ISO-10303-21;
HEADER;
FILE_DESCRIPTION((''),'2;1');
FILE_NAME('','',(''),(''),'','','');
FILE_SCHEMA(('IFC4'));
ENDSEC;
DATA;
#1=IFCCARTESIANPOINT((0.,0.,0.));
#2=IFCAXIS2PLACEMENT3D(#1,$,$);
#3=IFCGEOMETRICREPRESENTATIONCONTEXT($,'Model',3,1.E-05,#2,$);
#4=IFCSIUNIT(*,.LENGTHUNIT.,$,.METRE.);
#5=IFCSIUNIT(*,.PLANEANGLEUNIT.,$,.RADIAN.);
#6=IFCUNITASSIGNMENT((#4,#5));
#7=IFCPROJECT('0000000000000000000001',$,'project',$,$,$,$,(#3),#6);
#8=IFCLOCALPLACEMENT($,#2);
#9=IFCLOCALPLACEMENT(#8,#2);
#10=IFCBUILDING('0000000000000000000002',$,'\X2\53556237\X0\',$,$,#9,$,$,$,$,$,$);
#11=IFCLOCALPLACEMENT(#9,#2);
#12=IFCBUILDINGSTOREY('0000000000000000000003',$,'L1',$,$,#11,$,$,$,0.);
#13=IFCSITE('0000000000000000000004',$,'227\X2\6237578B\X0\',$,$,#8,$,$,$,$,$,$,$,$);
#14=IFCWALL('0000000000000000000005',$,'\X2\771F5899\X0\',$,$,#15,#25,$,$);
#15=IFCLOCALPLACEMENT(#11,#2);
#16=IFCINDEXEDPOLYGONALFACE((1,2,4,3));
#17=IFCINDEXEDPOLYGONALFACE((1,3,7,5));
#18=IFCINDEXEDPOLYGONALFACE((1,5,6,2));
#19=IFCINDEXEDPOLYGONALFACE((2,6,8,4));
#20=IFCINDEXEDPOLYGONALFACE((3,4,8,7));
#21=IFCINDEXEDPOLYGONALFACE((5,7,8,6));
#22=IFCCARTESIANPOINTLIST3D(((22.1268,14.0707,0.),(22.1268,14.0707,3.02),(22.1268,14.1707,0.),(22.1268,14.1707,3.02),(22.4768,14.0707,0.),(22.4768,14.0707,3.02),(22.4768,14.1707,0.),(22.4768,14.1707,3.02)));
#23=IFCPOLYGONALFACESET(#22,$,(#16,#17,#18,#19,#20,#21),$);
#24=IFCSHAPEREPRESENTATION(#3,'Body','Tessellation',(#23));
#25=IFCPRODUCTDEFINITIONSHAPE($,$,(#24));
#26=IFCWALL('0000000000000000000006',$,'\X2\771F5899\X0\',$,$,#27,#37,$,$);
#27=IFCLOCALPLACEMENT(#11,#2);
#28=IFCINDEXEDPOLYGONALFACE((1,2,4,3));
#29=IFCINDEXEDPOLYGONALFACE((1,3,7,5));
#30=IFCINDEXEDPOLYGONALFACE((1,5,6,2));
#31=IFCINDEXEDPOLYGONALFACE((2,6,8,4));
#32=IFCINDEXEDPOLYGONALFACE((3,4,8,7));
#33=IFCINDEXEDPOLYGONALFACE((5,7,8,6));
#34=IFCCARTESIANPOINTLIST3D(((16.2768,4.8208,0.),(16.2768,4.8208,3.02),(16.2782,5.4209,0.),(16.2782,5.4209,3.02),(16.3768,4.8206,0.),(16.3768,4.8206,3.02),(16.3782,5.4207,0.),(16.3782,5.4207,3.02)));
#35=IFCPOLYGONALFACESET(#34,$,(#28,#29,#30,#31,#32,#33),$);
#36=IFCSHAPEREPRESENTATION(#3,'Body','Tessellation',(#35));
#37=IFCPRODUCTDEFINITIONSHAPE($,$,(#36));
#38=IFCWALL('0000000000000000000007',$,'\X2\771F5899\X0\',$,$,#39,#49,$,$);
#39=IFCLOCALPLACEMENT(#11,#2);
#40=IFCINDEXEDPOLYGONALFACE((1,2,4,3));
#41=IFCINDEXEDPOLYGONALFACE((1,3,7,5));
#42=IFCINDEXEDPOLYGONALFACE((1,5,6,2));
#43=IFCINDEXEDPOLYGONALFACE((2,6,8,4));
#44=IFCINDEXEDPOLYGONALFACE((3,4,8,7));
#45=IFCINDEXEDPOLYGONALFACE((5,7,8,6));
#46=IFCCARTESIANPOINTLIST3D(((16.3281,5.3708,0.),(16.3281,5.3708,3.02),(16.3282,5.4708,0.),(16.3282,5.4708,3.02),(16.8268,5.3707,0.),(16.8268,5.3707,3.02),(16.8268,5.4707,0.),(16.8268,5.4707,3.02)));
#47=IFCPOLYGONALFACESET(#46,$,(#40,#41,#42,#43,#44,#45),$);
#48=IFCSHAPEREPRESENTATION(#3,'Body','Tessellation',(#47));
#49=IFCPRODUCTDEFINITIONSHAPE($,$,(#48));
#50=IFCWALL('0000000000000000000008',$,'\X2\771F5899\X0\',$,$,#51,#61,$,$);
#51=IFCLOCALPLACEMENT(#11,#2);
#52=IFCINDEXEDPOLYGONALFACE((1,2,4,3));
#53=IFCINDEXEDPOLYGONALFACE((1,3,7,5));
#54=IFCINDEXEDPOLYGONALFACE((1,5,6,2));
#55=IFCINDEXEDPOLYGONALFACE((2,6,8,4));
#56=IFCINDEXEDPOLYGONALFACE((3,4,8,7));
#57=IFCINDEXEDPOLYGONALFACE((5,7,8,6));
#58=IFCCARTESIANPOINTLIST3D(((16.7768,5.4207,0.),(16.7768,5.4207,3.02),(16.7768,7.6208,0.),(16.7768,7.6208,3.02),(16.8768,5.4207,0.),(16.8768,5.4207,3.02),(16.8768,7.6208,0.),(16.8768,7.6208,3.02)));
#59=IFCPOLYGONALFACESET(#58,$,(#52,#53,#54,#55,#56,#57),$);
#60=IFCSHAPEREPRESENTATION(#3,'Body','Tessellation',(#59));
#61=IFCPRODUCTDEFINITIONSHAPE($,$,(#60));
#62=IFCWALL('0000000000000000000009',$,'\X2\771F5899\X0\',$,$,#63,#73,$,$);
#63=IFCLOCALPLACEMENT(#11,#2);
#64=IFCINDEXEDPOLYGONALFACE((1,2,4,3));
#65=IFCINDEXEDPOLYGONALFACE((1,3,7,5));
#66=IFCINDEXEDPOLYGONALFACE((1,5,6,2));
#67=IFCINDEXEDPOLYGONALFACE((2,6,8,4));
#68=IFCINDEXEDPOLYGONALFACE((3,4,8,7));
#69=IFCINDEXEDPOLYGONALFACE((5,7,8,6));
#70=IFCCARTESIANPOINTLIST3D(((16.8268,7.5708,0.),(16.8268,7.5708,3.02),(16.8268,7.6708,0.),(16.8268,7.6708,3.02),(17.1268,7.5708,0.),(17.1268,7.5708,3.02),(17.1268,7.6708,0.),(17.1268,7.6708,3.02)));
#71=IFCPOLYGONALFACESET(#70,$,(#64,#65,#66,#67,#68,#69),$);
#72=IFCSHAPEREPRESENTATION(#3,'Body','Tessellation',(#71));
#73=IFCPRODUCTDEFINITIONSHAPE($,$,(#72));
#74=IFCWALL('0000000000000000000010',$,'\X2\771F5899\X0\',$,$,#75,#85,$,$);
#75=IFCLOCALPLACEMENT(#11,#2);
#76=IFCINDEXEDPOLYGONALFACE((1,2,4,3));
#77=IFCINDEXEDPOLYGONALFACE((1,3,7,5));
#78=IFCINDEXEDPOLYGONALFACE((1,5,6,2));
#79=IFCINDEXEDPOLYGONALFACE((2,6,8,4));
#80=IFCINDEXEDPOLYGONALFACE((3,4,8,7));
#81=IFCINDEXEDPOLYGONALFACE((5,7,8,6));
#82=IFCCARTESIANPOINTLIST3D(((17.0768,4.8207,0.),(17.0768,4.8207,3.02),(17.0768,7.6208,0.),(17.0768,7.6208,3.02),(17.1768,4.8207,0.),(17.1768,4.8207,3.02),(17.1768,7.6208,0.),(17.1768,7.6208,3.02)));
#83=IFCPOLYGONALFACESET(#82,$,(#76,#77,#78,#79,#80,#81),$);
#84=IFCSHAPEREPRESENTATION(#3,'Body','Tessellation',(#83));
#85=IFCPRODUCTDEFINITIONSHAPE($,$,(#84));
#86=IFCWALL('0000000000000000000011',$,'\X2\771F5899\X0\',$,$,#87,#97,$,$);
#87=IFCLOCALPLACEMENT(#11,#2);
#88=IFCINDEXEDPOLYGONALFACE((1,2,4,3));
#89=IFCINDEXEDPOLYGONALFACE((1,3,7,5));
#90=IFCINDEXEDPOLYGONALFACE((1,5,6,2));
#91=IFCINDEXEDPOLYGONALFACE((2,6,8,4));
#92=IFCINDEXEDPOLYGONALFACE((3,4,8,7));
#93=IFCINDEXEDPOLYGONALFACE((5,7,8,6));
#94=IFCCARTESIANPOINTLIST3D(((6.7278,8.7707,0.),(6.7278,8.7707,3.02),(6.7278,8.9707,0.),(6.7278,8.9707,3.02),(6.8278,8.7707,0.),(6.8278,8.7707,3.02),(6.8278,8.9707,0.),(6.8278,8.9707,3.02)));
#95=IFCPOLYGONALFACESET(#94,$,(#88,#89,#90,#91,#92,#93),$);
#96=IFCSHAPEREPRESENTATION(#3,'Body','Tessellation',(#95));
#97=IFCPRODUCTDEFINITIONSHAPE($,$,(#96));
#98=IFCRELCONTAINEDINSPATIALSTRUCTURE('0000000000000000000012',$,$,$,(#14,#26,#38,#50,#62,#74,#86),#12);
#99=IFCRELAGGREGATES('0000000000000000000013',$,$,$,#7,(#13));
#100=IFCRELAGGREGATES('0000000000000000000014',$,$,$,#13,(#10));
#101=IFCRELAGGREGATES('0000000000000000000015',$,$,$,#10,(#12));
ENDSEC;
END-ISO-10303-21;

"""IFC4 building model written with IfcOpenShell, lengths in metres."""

from ifc_helpers import new_model, si_unit, origin, place, context, project, spatial, polyline, outline, extrude, element, save


model = new_model("IFC4")

# Units and contexts
model_context = context("Model", 3, precision=1e-05, world=origin())
ifc_project = project(units=[si_unit("LENGTHUNIT", "METRE"), si_unit("PLANEANGLEUNIT", "RADIAN")], contexts=[model_context])

# Site, building, storey
site_placement = place(None, origin())
site = spatial("IfcSite", under=ifc_project, at=site_placement, Name="227户型")
building_placement = place(site_placement, origin())
building = spatial("IfcBuilding", under=site, at=building_placement, Name="单户")
storey_placement = place(building_placement, origin())
storey = spatial("IfcBuildingStorey", under=building, at=storey_placement, Name="L1", Elevation=0.0)

# Walls
wall_1_placement = place(storey_placement, origin())
element("IfcWall", 1, at=wall_1_placement, inside=storey, Name="真墙", context=model_context, shape_type="SweptSolid", body=[
    extrude(outline(polyline([(22.4768, 14.0707), (22.1268, 14.0707), (22.1268, 14.1707), (22.4768, 14.1707), (22.4768, 14.0707)])), origin(), (0.0, 0.0, 1.0), 3.02),
])
wall_2_placement = place(storey_placement, origin())
element("IfcWall", 2, at=wall_2_placement, inside=storey, Name="真墙", context=model_context, shape_type="SweptSolid", body=[
    extrude(outline(polyline([(16.2768, 4.8208), (16.2782, 5.4209), (16.3782, 5.4207), (16.3768, 4.8206), (16.2768, 4.8208)])), origin(), (0.0, 0.0, 1.0), 3.02),
])
wall_3_placement = place(storey_placement, origin())
element("IfcWall", 3, at=wall_3_placement, inside=storey, Name="真墙", context=model_context, shape_type="SweptSolid", body=[
    extrude(outline(polyline([(16.3282, 5.4708), (16.8268, 5.4707), (16.8268, 5.3707), (16.3281, 5.3708), (16.3282, 5.4708)])), origin(), (0.0, 0.0, 1.0), 3.02),
])
wall_4_placement = place(storey_placement, origin())
element("IfcWall", 4, at=wall_4_placement, inside=storey, Name="真墙", context=model_context, shape_type="SweptSolid", body=[
    extrude(outline(polyline([(16.7768, 5.4207), (16.7768, 7.6208), (16.8768, 7.6208), (16.8768, 5.4207), (16.7768, 5.4207)])), origin(), (0.0, 0.0, 1.0), 3.02),
])
wall_5_placement = place(storey_placement, origin())
element("IfcWall", 5, at=wall_5_placement, inside=storey, Name="真墙", context=model_context, shape_type="SweptSolid", body=[
    extrude(outline(polyline([(16.8268, 7.6708), (17.1268, 7.6708), (17.1268, 7.5708), (16.8268, 7.5708), (16.8268, 7.6708)])), origin(), (0.0, 0.0, 1.0), 3.02),
])
wall_6_placement = place(storey_placement, origin())
element("IfcWall", 6, at=wall_6_placement, inside=storey, Name="真墙", context=model_context, shape_type="SweptSolid", body=[
    extrude(outline(polyline([(17.1768, 7.6208), (17.1768, 4.8207), (17.0768, 4.8207), (17.0768, 7.6208), (17.1768, 7.6208)])), origin(), (0.0, 0.0, 1.0), 3.02),
])

# Wall
wall_7_placement = place(storey_placement, origin())
element("IfcWall", 7, at=wall_7_placement, inside=storey, Name="真墙", context=model_context, shape_type="SweptSolid", body=[
    extrude(outline(polyline([(6.8278, 8.9707), (6.8278, 8.7707), (6.7278, 8.7707), (6.7278, 8.9707), (6.8278, 8.9707)])), origin(), (0.0, 0.0, 1.0), 3.02),
])

save(model, "model.ifc")
